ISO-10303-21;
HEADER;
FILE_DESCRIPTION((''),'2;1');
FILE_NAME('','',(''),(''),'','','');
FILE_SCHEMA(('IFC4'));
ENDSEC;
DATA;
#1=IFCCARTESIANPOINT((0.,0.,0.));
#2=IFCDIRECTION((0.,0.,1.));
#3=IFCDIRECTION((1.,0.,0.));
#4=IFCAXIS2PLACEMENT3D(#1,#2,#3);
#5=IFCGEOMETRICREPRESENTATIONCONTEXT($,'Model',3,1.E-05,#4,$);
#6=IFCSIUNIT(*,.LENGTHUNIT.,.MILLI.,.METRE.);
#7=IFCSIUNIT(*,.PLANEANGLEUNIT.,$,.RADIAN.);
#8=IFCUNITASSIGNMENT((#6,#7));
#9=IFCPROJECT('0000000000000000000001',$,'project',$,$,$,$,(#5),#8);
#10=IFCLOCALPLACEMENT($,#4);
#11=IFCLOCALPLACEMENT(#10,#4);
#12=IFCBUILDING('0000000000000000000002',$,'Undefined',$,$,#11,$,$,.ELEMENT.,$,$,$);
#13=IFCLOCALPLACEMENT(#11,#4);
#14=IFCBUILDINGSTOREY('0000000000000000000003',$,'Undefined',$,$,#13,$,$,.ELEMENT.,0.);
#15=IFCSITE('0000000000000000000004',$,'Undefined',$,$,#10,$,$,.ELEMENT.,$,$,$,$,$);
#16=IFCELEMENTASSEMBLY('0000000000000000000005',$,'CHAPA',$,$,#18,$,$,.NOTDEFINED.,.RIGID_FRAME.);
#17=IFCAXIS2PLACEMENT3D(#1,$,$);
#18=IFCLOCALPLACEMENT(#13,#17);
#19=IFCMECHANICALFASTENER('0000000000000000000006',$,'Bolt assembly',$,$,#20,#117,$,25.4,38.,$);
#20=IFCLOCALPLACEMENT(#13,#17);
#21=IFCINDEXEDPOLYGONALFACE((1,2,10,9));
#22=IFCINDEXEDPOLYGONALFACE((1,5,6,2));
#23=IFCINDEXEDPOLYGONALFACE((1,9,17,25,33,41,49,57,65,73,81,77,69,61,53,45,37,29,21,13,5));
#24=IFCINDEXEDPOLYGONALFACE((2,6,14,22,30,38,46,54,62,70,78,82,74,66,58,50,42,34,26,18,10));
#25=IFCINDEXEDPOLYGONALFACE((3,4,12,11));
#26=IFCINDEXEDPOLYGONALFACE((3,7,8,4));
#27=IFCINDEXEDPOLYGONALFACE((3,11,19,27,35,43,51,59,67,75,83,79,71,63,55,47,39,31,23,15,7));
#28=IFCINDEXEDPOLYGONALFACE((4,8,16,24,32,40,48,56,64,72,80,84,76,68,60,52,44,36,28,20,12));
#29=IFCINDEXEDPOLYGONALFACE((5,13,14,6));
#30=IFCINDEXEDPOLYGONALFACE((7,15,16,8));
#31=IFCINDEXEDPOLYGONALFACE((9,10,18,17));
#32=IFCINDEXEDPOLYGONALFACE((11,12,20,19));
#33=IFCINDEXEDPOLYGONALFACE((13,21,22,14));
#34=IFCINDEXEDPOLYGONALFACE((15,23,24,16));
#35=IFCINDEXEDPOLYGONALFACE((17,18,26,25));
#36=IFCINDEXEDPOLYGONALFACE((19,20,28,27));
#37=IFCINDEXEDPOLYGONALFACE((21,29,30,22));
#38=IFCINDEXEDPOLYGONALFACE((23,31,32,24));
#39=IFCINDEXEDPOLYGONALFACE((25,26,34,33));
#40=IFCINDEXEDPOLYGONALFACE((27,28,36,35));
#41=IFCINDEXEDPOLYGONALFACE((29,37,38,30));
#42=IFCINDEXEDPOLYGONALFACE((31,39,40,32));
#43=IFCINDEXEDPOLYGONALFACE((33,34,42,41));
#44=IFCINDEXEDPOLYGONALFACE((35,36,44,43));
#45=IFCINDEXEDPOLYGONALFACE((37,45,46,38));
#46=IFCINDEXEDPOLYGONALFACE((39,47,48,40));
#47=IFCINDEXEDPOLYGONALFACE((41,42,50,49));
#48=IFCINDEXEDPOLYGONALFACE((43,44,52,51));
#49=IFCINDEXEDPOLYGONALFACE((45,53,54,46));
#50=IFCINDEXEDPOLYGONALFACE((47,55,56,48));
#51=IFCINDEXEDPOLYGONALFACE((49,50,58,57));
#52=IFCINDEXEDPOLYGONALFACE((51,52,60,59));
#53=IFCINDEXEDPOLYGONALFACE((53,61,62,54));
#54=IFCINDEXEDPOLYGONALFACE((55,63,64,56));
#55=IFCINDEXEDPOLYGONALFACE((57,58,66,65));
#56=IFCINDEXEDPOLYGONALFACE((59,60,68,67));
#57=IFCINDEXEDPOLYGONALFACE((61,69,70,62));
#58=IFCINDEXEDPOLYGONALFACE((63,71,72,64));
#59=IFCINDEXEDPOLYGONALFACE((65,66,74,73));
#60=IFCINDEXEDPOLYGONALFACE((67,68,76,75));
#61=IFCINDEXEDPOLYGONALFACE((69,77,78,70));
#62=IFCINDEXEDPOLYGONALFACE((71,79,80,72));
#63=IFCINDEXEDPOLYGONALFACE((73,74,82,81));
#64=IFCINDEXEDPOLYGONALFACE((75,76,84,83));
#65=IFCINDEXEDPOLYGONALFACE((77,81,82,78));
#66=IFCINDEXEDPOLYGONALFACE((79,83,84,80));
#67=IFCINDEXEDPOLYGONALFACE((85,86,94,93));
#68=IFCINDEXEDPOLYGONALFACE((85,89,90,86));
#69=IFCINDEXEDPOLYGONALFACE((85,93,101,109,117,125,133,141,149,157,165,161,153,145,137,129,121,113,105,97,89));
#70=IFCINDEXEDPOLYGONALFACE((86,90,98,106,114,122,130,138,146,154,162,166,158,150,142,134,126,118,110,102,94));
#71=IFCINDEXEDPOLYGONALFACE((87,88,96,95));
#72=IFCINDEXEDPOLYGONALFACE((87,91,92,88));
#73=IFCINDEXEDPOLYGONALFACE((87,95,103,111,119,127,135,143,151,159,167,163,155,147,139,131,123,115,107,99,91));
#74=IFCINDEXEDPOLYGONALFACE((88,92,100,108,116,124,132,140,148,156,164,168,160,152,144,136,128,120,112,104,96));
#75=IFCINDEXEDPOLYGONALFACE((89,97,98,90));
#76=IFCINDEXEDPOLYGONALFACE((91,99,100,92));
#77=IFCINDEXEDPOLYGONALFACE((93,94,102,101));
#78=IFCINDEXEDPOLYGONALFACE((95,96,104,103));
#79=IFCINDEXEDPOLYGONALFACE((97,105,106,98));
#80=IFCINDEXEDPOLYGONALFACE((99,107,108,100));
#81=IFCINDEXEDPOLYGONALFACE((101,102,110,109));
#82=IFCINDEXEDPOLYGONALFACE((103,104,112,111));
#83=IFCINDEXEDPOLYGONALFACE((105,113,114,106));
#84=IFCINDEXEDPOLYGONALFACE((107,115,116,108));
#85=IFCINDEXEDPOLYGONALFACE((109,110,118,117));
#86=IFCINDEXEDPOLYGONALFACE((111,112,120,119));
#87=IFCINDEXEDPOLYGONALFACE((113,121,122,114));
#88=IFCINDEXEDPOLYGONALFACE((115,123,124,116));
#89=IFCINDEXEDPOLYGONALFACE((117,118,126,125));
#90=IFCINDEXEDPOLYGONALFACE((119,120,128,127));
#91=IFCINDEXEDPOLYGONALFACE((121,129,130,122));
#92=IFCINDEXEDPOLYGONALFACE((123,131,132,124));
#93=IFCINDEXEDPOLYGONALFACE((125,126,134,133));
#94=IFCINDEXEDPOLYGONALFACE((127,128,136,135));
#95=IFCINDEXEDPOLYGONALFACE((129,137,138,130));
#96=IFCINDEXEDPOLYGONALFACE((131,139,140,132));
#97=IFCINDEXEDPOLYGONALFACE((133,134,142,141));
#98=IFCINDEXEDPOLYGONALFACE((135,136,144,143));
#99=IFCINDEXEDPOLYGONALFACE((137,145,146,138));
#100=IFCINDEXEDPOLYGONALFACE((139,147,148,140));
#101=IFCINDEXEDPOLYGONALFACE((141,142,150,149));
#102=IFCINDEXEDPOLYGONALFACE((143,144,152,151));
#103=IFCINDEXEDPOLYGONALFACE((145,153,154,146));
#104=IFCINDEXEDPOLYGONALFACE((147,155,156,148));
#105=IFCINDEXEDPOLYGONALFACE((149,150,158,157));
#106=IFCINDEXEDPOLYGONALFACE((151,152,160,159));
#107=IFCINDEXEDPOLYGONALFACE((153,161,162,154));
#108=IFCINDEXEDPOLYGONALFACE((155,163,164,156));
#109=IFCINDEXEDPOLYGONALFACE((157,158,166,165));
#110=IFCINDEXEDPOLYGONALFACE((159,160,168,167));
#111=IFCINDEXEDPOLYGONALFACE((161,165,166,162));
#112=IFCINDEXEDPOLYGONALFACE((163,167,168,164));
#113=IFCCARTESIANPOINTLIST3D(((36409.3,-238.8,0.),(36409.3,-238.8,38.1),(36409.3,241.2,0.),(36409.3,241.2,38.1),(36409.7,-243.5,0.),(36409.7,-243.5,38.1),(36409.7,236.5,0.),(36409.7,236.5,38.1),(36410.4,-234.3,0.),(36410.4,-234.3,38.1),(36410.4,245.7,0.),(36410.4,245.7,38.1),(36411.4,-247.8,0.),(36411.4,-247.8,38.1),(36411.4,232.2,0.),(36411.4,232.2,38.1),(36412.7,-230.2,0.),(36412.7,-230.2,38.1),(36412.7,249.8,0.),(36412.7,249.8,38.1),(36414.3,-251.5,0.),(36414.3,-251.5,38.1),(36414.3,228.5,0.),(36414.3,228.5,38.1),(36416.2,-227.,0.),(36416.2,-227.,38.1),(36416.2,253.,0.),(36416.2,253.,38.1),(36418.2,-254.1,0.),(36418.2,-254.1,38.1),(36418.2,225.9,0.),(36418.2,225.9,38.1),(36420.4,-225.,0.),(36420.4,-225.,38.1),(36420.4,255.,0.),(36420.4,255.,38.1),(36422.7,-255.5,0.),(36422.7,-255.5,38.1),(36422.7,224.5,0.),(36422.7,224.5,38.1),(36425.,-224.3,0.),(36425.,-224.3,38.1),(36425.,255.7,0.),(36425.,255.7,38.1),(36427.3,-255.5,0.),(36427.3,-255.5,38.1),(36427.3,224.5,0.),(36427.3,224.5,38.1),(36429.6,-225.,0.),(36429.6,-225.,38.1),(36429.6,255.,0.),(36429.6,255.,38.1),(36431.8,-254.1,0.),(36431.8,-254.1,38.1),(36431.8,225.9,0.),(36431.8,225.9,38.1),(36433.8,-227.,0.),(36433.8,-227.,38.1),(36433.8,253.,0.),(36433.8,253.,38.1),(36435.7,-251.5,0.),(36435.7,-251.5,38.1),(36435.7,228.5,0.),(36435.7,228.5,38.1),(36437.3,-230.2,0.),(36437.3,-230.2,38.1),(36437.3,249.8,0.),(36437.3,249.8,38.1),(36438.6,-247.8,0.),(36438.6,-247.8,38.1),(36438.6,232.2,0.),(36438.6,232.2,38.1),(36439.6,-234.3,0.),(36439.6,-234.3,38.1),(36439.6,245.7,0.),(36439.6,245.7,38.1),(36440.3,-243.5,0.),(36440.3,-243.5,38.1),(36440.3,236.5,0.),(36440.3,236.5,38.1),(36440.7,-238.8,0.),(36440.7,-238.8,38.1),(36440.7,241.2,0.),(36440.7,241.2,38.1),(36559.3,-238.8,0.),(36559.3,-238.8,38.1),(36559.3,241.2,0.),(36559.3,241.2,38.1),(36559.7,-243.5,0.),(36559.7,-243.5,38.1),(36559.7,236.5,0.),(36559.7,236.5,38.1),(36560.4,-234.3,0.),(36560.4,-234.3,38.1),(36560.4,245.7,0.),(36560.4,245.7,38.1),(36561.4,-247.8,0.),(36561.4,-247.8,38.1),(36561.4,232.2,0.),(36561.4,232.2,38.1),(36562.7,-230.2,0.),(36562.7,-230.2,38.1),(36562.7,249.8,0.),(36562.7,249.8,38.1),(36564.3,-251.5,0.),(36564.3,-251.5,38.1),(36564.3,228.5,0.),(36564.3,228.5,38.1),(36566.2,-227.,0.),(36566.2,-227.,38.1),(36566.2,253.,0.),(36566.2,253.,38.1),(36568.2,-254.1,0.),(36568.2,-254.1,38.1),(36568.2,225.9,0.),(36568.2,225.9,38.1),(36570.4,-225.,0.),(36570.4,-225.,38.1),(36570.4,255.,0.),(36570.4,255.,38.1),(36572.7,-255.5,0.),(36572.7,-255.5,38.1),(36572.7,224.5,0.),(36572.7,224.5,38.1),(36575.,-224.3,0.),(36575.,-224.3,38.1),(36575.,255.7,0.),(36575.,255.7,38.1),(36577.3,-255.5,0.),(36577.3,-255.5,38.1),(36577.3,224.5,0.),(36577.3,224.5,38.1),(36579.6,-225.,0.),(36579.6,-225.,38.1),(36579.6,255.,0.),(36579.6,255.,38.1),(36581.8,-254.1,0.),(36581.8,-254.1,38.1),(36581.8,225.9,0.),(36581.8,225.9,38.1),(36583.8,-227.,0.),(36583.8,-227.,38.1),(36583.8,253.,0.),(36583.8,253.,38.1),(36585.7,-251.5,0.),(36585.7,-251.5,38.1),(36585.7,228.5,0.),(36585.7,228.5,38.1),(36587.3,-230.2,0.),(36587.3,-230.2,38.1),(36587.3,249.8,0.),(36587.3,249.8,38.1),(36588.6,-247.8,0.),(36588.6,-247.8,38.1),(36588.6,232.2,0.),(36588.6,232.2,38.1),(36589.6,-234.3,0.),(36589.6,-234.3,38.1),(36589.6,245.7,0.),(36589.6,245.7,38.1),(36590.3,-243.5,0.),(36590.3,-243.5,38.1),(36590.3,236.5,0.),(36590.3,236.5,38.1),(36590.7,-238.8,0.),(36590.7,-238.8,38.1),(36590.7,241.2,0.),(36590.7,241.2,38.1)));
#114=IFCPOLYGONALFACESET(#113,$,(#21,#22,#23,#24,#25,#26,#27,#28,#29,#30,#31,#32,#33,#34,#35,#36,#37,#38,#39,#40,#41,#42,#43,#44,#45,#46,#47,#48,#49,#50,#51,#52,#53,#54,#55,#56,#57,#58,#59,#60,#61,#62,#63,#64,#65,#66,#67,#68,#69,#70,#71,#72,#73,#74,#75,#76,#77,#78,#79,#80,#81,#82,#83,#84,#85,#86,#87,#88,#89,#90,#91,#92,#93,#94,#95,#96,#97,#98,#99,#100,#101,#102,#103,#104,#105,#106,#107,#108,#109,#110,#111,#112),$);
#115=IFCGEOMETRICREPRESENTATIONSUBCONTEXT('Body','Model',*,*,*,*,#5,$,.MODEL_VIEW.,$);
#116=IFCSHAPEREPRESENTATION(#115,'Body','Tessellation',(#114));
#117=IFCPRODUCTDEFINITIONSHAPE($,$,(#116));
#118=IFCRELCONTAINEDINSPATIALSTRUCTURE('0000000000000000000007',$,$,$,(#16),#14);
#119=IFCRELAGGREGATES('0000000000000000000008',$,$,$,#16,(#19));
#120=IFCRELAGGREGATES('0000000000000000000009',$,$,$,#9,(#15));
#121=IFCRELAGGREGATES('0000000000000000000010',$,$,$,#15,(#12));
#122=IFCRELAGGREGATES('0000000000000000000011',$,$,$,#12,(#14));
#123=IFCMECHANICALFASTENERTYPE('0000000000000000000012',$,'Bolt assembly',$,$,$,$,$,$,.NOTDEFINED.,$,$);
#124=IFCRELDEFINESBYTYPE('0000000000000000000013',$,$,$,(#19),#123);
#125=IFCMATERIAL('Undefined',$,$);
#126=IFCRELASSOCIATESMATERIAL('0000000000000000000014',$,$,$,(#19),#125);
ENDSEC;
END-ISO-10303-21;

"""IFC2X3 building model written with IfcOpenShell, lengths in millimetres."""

from ifc_helpers import new_model, si_unit, frame, origin_with_axes, origin_2d_with_axis, place, context, subcontext, project, spatial, circle, extrude, source, transform, mapped, material, type_object, element, aggregate, save


model = new_model("IFC2X3")

# Units and contexts
model_context = context("Model", 3, precision=1e-05, world=origin_with_axes())
body_context = subcontext(model_context, "Body", "Model", "MODEL_VIEW")
ifc_project = project(units=[si_unit("LENGTHUNIT", "METRE", prefix="MILLI"), si_unit("PLANEANGLEUNIT", "RADIAN")], contexts=[model_context])

# Site, building, storey
site_placement = place(None, origin_with_axes())
site = spatial("IfcSite", under=ifc_project, at=site_placement, Name="Undefined", CompositionType="ELEMENT")
building_placement = place(site_placement, origin_with_axes())
building = spatial("IfcBuilding", under=site, at=building_placement, Name="Undefined", CompositionType="ELEMENT")
storey_placement = place(building_placement, origin_with_axes())
storey = spatial("IfcBuildingStorey", under=building, at=storey_placement, Name="Undefined", CompositionType="ELEMENT", Elevation=0.0)

# Element assembly
assembly_1_placement = place(storey_placement, origin_with_axes())
assembly_1 = element("IfcElementAssembly", 1, at=assembly_1_placement, inside=storey, Name="CHAPA", AssemblyPlace="NOTDEFINED", PredefinedType="RIGID_FRAME")

# Shared definitions
ifc_material_1 = material(Name="Undefined")
mechanical_fastener_type = type_object("IfcMechanicalFastenerType", Name="Bolt assembly")

# Mechanical fastener
shared_shape_1 = source(origin_with_axes(), body_context, "Body", "SweptSolid", [
    extrude(circle(Radius=15.7, at=origin_2d_with_axis()), frame((0.0, -38.0, 0.0), z_axis=(0.0, 1.0, 0.0), x_axis=(1.0, 0.0, 0.0)), (0.0, 0.0, 1.0), 38.1),
])
mechanical_fastener_1_placement = place(assembly_1_placement, frame((36500.0, -240.0, 38.0), z_axis=(1.0, 0.0, 0.0), x_axis=(0.0, 1.0, 0.0)))
mechanical_fastener_1 = element("IfcMechanicalFastener", 2, at=mechanical_fastener_1_placement, type_object=mechanical_fastener_type, material=ifc_material_1, Name="Bolt assembly", NominalDiameter=25.4, NominalLength=38.0, context=body_context, shape_type="MappedRepresentation", body=[
    mapped(shared_shape_1, transform((0.0, 0.0, -75.0))),
    mapped(shared_shape_1, transform((0.0, 0.0, 75.0))),
    mapped(shared_shape_1, transform((480.0, 0.0, -75.0))),
    mapped(shared_shape_1, transform((480.0, 0.0, 75.0))),
])
aggregate(assembly_1, [mechanical_fastener_1])

save(model, "model.ifc")
